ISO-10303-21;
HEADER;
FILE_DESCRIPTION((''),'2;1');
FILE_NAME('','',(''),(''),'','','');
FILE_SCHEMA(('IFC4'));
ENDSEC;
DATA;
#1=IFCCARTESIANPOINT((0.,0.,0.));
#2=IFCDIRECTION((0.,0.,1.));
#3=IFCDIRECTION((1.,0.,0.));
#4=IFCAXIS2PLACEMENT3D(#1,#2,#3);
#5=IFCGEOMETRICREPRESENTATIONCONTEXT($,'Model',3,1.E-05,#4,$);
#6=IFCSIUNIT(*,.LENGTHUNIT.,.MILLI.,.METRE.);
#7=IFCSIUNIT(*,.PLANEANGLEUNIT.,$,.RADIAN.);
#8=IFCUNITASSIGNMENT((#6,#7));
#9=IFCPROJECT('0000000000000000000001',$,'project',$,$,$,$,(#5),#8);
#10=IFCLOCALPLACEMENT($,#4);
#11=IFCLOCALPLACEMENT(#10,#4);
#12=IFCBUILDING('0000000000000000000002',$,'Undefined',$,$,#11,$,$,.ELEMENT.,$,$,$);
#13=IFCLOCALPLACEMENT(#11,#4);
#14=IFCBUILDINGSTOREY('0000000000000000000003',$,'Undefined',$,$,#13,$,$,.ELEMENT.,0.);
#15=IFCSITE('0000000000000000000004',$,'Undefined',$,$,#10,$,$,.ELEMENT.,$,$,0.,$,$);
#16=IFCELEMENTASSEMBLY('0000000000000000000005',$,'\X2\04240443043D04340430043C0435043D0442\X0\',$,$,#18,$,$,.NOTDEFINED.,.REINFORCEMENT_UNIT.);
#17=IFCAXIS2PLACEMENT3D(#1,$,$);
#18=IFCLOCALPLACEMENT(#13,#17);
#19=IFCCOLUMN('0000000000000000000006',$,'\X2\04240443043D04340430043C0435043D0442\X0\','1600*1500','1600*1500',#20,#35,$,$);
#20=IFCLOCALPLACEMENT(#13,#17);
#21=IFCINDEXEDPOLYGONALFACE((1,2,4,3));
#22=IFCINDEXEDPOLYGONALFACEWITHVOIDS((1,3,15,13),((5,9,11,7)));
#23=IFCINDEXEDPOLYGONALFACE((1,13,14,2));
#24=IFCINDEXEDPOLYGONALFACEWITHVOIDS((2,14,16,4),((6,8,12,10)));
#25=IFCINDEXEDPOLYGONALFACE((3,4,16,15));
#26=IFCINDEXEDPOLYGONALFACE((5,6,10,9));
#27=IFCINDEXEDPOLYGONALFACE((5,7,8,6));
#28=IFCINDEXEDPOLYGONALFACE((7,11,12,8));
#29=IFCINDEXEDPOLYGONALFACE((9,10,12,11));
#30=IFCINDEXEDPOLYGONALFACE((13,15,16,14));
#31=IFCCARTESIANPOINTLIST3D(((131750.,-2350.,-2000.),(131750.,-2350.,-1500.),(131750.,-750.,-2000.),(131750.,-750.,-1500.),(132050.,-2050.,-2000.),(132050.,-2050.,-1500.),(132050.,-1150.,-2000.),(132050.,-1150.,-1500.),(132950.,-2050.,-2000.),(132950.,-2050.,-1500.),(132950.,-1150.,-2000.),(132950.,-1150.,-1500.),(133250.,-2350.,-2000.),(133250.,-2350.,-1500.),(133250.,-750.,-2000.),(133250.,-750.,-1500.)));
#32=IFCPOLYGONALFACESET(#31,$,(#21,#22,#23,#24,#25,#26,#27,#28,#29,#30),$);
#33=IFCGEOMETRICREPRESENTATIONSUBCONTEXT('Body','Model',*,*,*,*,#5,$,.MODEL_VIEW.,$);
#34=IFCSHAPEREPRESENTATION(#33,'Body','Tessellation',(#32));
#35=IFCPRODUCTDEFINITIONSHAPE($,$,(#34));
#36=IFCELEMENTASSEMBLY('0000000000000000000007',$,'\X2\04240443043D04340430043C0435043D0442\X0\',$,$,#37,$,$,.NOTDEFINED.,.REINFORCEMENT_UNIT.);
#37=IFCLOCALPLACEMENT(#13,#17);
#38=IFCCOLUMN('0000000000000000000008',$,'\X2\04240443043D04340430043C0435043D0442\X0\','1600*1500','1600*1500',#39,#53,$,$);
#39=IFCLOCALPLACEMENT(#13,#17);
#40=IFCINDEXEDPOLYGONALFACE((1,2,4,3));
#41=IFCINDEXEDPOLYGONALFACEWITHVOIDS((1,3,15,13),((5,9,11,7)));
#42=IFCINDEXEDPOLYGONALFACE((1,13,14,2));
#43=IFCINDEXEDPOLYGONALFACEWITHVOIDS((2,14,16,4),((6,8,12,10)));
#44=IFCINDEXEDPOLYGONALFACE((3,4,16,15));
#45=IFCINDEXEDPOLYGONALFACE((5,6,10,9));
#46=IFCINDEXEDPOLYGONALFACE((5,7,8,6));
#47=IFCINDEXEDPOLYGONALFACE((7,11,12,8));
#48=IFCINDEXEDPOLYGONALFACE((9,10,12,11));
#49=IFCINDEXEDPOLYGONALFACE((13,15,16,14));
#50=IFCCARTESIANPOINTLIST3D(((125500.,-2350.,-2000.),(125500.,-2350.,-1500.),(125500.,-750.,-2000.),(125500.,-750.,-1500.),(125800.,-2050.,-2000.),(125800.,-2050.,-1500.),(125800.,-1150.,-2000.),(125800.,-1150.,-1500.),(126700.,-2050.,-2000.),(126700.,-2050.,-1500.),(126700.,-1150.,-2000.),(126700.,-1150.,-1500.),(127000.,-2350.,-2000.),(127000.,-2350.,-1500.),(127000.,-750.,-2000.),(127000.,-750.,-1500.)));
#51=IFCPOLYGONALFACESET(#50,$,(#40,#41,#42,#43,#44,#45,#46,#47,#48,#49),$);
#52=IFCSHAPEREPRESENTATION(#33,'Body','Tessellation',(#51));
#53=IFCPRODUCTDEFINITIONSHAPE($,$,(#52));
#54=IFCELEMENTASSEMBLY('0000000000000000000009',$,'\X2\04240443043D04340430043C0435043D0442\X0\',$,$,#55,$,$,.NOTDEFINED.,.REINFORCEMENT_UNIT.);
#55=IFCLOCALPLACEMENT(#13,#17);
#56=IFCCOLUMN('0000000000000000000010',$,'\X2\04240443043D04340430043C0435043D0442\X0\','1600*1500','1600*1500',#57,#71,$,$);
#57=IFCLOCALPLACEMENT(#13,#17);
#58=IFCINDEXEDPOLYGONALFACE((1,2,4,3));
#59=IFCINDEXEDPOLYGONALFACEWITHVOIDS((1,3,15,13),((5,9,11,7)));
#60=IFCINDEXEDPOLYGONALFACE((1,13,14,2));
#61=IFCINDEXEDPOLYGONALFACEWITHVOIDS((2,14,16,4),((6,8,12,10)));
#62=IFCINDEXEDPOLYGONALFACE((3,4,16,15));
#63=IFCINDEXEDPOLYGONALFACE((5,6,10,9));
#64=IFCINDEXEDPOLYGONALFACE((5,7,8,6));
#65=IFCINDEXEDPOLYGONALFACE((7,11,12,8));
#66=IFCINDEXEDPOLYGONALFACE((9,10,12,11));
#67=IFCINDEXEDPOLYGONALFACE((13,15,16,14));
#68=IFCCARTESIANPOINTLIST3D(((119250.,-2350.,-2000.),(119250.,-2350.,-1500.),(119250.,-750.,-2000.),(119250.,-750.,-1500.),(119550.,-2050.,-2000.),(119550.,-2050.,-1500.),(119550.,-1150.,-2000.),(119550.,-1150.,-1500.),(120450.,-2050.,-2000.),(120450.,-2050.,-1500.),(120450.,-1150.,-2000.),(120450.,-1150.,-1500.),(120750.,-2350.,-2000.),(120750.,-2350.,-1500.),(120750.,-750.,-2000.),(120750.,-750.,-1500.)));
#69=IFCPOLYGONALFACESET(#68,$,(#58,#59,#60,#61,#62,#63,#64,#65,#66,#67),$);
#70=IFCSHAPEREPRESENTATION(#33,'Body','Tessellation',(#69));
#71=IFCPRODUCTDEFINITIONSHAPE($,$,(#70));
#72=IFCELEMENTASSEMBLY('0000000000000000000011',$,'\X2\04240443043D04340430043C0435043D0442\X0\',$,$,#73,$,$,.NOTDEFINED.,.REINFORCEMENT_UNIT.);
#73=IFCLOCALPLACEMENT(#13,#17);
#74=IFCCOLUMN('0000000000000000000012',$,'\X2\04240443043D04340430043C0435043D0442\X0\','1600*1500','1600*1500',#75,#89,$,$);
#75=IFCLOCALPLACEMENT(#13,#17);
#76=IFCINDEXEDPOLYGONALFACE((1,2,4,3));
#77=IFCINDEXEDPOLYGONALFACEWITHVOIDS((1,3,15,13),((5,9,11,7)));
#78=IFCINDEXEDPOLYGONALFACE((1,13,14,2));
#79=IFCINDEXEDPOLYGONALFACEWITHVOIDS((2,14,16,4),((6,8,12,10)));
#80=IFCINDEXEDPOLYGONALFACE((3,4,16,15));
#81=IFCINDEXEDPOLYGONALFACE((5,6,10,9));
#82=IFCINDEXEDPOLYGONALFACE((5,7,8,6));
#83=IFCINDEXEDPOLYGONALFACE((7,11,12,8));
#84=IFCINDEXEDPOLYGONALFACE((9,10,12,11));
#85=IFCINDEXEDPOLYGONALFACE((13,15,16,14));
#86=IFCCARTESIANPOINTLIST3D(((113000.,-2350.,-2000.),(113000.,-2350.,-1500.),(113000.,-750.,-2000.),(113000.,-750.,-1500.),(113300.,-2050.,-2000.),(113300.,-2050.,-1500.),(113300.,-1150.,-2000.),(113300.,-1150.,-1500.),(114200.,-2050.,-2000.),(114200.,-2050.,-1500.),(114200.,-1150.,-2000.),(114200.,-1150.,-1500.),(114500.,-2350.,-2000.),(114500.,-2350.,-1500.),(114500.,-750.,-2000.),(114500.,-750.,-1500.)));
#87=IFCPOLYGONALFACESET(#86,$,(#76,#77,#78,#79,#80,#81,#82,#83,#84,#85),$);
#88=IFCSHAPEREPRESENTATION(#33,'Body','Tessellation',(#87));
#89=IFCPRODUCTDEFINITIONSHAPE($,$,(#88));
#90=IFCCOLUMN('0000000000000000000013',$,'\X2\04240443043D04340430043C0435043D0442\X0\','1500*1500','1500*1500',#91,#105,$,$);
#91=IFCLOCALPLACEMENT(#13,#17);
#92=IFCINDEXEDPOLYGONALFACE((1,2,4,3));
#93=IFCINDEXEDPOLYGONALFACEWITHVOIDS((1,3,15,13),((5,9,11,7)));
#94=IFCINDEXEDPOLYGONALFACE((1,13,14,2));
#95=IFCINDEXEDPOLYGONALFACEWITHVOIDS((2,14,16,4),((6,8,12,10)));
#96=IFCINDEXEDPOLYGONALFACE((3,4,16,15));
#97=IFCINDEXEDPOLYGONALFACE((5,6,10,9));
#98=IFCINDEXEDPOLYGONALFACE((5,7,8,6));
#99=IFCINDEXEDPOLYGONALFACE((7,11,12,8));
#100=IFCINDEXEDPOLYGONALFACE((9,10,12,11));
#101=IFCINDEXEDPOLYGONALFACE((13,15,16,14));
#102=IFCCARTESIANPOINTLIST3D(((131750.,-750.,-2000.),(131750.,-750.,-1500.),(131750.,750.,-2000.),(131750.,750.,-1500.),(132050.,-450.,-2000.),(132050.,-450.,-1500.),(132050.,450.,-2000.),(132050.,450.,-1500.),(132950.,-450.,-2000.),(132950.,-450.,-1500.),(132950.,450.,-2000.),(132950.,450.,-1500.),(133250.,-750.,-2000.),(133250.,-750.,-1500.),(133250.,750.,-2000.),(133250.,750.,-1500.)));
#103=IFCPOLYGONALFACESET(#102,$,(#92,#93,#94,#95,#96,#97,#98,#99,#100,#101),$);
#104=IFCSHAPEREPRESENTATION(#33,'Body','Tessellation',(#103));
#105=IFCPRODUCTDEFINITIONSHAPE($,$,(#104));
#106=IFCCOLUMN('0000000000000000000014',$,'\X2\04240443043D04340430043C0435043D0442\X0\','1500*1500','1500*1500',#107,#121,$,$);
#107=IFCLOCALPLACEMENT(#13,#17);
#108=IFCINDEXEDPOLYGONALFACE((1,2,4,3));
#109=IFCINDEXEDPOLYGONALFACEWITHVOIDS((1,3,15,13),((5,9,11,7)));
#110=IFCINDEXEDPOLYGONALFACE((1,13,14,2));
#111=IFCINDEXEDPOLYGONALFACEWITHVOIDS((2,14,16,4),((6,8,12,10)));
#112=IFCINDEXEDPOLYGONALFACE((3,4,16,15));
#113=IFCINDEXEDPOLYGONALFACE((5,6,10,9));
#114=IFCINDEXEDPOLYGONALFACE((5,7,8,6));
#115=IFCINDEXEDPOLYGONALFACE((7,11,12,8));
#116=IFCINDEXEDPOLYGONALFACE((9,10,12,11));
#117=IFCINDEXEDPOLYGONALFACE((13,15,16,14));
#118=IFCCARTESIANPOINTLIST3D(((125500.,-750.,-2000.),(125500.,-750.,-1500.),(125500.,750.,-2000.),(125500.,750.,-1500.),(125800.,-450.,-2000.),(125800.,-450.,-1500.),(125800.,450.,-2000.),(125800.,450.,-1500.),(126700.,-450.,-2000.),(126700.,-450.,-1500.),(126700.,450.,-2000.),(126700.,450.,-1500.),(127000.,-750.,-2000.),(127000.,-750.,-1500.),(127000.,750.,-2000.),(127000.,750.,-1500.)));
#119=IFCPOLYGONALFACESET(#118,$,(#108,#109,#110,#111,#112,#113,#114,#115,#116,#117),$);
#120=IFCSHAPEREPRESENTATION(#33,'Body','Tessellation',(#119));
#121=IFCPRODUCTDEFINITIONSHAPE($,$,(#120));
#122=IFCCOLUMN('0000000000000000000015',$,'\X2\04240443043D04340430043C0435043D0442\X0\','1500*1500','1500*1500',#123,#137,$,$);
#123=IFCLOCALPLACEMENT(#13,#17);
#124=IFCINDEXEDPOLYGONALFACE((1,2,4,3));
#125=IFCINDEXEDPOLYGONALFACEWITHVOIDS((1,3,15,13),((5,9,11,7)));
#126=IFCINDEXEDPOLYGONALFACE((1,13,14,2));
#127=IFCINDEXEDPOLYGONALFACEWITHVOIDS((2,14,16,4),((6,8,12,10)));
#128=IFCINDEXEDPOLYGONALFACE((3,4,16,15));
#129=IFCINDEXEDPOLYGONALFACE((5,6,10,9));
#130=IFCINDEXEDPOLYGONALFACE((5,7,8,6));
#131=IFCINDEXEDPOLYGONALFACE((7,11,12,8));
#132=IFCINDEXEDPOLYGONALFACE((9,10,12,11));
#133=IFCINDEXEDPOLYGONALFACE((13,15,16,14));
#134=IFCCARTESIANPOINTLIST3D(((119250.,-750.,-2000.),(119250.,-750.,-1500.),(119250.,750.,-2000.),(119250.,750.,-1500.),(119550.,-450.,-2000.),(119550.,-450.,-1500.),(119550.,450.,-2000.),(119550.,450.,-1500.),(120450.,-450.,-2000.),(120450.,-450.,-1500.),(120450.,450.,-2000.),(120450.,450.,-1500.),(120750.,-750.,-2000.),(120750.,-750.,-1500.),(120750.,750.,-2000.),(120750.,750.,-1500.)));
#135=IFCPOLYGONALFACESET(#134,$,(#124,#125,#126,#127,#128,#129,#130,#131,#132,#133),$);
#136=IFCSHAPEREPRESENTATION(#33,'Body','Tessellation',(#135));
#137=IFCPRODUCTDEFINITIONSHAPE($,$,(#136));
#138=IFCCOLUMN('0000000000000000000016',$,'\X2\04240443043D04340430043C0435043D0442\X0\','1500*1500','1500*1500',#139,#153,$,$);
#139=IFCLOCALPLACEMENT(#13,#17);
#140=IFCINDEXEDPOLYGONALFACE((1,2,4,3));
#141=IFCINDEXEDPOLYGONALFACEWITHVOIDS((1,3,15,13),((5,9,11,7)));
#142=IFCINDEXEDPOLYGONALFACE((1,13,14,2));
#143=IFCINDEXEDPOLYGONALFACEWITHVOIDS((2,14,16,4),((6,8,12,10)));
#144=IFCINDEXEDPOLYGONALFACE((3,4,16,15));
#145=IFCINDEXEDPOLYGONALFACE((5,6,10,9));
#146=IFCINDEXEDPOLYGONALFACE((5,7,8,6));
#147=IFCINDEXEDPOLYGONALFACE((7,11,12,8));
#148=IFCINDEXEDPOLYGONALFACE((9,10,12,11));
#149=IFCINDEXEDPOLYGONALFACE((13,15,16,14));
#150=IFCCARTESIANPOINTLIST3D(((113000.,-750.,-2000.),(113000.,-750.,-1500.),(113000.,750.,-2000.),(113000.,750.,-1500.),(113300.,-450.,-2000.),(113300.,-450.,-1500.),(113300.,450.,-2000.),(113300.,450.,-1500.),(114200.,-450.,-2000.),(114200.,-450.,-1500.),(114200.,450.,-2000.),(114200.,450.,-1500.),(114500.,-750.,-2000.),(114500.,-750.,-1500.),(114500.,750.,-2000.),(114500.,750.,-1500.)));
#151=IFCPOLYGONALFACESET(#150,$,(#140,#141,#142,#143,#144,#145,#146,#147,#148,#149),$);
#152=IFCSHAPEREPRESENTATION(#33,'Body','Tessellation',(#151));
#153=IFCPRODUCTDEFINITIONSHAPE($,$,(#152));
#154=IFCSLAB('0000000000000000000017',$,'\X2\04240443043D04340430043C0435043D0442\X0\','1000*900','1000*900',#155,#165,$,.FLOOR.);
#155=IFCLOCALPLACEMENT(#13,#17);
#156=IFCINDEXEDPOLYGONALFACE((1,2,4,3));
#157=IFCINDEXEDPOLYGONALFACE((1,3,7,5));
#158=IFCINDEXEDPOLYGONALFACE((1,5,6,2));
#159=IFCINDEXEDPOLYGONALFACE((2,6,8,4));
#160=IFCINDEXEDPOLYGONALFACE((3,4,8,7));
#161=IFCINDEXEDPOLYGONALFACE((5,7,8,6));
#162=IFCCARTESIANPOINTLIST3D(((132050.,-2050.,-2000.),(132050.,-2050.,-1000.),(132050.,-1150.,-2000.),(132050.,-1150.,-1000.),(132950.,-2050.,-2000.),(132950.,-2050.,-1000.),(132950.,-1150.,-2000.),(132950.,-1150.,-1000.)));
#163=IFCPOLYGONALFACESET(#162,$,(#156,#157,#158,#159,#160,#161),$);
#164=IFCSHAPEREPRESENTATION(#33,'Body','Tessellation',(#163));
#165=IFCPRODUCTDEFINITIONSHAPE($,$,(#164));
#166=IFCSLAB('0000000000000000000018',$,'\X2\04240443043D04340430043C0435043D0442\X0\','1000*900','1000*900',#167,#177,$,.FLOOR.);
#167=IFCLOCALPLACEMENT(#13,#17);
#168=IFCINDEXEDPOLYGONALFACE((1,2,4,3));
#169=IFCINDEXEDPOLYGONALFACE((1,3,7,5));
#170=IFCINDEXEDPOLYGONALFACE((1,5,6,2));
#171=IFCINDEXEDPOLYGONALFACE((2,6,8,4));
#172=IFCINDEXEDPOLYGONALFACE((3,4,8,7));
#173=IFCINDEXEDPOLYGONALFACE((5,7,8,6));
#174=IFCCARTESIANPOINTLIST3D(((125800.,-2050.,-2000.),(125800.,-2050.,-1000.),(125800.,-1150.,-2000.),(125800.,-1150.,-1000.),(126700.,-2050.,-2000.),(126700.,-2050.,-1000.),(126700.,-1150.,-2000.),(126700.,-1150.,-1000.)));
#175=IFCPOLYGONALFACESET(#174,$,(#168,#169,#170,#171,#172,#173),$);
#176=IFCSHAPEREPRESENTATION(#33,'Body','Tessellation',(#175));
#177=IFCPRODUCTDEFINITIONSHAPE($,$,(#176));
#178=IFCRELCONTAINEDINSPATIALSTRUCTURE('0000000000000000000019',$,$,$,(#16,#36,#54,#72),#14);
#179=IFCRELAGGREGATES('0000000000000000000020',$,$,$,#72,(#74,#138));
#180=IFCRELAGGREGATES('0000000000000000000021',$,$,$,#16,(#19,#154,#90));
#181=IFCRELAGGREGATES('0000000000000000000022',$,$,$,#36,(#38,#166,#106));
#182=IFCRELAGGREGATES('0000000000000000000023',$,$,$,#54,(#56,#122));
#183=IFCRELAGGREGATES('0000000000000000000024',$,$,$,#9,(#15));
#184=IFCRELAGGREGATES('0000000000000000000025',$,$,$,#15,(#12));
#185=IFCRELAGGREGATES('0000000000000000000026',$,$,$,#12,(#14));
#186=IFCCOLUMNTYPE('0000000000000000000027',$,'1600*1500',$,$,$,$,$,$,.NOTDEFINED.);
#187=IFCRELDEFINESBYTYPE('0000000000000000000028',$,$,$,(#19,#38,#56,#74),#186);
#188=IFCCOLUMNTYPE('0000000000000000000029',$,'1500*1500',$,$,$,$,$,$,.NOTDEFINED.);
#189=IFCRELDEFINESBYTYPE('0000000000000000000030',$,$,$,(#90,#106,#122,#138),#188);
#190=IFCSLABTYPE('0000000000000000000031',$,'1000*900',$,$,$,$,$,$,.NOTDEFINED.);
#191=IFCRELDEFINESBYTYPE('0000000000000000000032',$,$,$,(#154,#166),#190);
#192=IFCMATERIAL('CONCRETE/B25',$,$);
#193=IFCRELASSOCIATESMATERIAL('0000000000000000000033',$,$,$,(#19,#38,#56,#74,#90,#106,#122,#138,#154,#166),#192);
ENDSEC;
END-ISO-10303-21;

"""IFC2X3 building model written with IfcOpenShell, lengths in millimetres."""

from ifc_helpers import new_model, si_unit, frame, origin_with_axes, origin_2d_with_axis, place, context, subcontext, project, spatial, polyline, rectangle, outline, extrude, boolean, material, type_object, element, aggregate, save


model = new_model("IFC2X3")

# Units and contexts
model_context = context("Model", 3, precision=1e-05, world=origin_with_axes())
body_context = subcontext(model_context, "Body", "Model", "MODEL_VIEW")
ifc_project = project(units=[si_unit("LENGTHUNIT", "METRE", prefix="MILLI"), si_unit("PLANEANGLEUNIT", "RADIAN")], contexts=[model_context])

# Site, building, storey
site_placement = place(None, origin_with_axes())
site = spatial("IfcSite", under=ifc_project, at=site_placement, Name="Undefined", CompositionType="ELEMENT", RefElevation=0.0)
building_placement = place(site_placement, origin_with_axes())
building = spatial("IfcBuilding", under=site, at=building_placement, Name="Undefined", CompositionType="ELEMENT")
storey_placement = place(building_placement, origin_with_axes())
storey = spatial("IfcBuildingStorey", under=building, at=storey_placement, Name="Undefined", CompositionType="ELEMENT", Elevation=0.0)

# Element assemblies, columns
assembly_1_placement = place(storey_placement, origin_with_axes())
assembly_1 = element("IfcElementAssembly", 1, at=assembly_1_placement, inside=storey, Name="Фундамент", AssemblyPlace="NOTDEFINED", PredefinedType="REINFORCEMENT_UNIT")
ifc_material_1 = material(Name="CONCRETE/B25")
column_type_1 = type_object("IfcColumnType", Name="1600*1500", PredefinedType="NOTDEFINED")
column_1_placement = place(assembly_1_placement, frame((132500.0, -1550.0, -2000.0), z_axis=(0.0, 0.0, 1.0), x_axis=(0.0, -1.0, 0.0)))
column_1 = element("IfcColumn", 2, at=column_1_placement, type_object=column_type_1, material=ifc_material_1, Name="Фундамент", Description="1600*1500", ObjectType="1600*1500", context=body_context, shape_type="CSG", body=[
    boolean("DIFFERENCE", extrude(rectangle(XDim=1500.0, YDim=1600.0, at=origin_2d_with_axis()), frame((0.0, 0.0, 500.0), z_axis=(0.0, 0.0, -1.0), x_axis=(0.0, 1.0, 0.0)), (0.0, 0.0, 1.0), 500.0), extrude(outline(polyline([(0.0, 0.0), (900.0, 0.0), (900.0, 900.0), (0.0, 900.0), (0.0, 0.0)])), frame((-400.0, -450.0, -100.0), z_axis=(0.0, 0.0, 1.0), x_axis=(1.0, 0.0, 0.0)), (0.0, 0.0, 1.0), 700.0)),
])
assembly_2_placement = place(storey_placement, origin_with_axes())
assembly_2 = element("IfcElementAssembly", 3, at=assembly_2_placement, inside=storey, Name="Фундамент", AssemblyPlace="NOTDEFINED", PredefinedType="REINFORCEMENT_UNIT")
column_2_placement = place(assembly_2_placement, frame((126250.0, -1550.0, -2000.0), z_axis=(0.0, 0.0, 1.0), x_axis=(0.0, -1.0, 0.0)))
column_2 = element("IfcColumn", 4, at=column_2_placement, type_object=column_type_1, material=ifc_material_1, Name="Фундамент", Description="1600*1500", ObjectType="1600*1500", context=body_context, shape_type="CSG", body=[
    boolean("DIFFERENCE", extrude(rectangle(XDim=1500.0, YDim=1600.0, at=origin_2d_with_axis()), frame((0.0, 0.0, 500.0), z_axis=(0.0, 0.0, -1.0), x_axis=(0.0, 1.0, 0.0)), (0.0, 0.0, 1.0), 500.0), extrude(outline(polyline([(0.0, 0.0), (900.0, 0.0), (900.0, 900.0), (0.0, 900.0), (0.0, 0.0)])), frame((-400.0, -450.0, -100.0), z_axis=(0.0, 0.0, 1.0), x_axis=(1.0, 0.0, 0.0)), (0.0, 0.0, 1.0), 700.0)),
])
assembly_3_placement = place(storey_placement, origin_with_axes())
assembly_3 = element("IfcElementAssembly", 5, at=assembly_3_placement, inside=storey, Name="Фундамент", AssemblyPlace="NOTDEFINED", PredefinedType="REINFORCEMENT_UNIT")
column_3_placement = place(assembly_3_placement, frame((120000.0, -1550.0, -2000.0), z_axis=(0.0, 0.0, 1.0), x_axis=(0.0, -1.0, 0.0)))
column_3 = element("IfcColumn", 6, at=column_3_placement, type_object=column_type_1, material=ifc_material_1, Name="Фундамент", Description="1600*1500", ObjectType="1600*1500", context=body_context, shape_type="CSG", body=[
    boolean("DIFFERENCE", extrude(rectangle(XDim=1500.0, YDim=1600.0, at=origin_2d_with_axis()), frame((0.0, 0.0, 500.0), z_axis=(0.0, 0.0, -1.0), x_axis=(0.0, 1.0, 0.0)), (0.0, 0.0, 1.0), 500.0), extrude(outline(polyline([(0.0, 0.0), (900.0, 0.0), (900.0, 900.0), (0.0, 900.0), (0.0, 0.0)])), frame((-400.0, -450.0, -100.0), z_axis=(0.0, 0.0, 1.0), x_axis=(1.0, 0.0, 0.0)), (0.0, 0.0, 1.0), 700.0)),
])
assembly_4_placement = place(storey_placement, origin_with_axes())
assembly_4 = element("IfcElementAssembly", 7, at=assembly_4_placement, inside=storey, Name="Фундамент", AssemblyPlace="NOTDEFINED", PredefinedType="REINFORCEMENT_UNIT")
column_4_placement = place(assembly_4_placement, frame((113750.0, -1550.0, -2000.0), z_axis=(0.0, 0.0, 1.0), x_axis=(0.0, -1.0, 0.0)))
column_4 = element("IfcColumn", 8, at=column_4_placement, type_object=column_type_1, material=ifc_material_1, Name="Фундамент", Description="1600*1500", ObjectType="1600*1500", context=body_context, shape_type="CSG", body=[
    boolean("DIFFERENCE", extrude(rectangle(XDim=1500.0, YDim=1600.0, at=origin_2d_with_axis()), frame((0.0, 0.0, 500.0), z_axis=(0.0, 0.0, -1.0), x_axis=(0.0, 1.0, 0.0)), (0.0, 0.0, 1.0), 500.0), extrude(outline(polyline([(0.0, 0.0), (900.0, 0.0), (900.0, 900.0), (0.0, 900.0), (0.0, 0.0)])), frame((-400.0, -450.0, -100.0), z_axis=(0.0, 0.0, 1.0), x_axis=(1.0, 0.0, 0.0)), (0.0, 0.0, 1.0), 700.0)),
])

# Columns
column_type_2 = type_object("IfcColumnType", Name="1500*1500", PredefinedType="NOTDEFINED")
column_5_placement = place(assembly_1_placement, frame((132500.0, 0.0, -2000.0), z_axis=(0.0, 0.0, 1.0), x_axis=(0.0, -1.0, 0.0)))
column_5 = element("IfcColumn", 9, at=column_5_placement, type_object=column_type_2, material=ifc_material_1, Name="Фундамент", Description="1500*1500", ObjectType="1500*1500", context=body_context, shape_type="CSG", body=[
    boolean("DIFFERENCE", extrude(rectangle(XDim=1500.0, YDim=1500.0, at=origin_2d_with_axis()), frame((0.0, 0.0, 500.0), z_axis=(0.0, 0.0, -1.0), x_axis=(0.0, 1.0, 0.0)), (0.0, 0.0, 1.0), 500.0), extrude(outline(polyline([(0.0, 0.0), (900.0, 0.0), (900.0, 900.0), (0.0, 900.0), (0.0, 0.0)])), frame((-450.0, -450.0, -100.0), z_axis=(0.0, 0.0, 1.0), x_axis=(1.0, 0.0, 0.0)), (0.0, 0.0, 1.0), 700.0)),
])
column_6_placement = place(assembly_2_placement, frame((126250.0, 0.0, -2000.0), z_axis=(0.0, 0.0, 1.0), x_axis=(0.0, -1.0, 0.0)))
column_6 = element("IfcColumn", 10, at=column_6_placement, type_object=column_type_2, material=ifc_material_1, Name="Фундамент", Description="1500*1500", ObjectType="1500*1500", context=body_context, shape_type="CSG", body=[
    boolean("DIFFERENCE", extrude(rectangle(XDim=1500.0, YDim=1500.0, at=origin_2d_with_axis()), frame((0.0, 0.0, 500.0), z_axis=(0.0, 0.0, -1.0), x_axis=(0.0, 1.0, 0.0)), (0.0, 0.0, 1.0), 500.0), extrude(outline(polyline([(0.0, 0.0), (900.0, 0.0), (900.0, 900.0), (0.0, 900.0), (0.0, 0.0)])), frame((-450.0, -450.0, -100.0), z_axis=(0.0, 0.0, 1.0), x_axis=(1.0, 0.0, 0.0)), (0.0, 0.0, 1.0), 700.0)),
])
column_7_placement = place(assembly_3_placement, frame((120000.0, 0.0, -2000.0), z_axis=(0.0, 0.0, 1.0), x_axis=(0.0, -1.0, 0.0)))
column_7 = element("IfcColumn", 11, at=column_7_placement, type_object=column_type_2, material=ifc_material_1, Name="Фундамент", Description="1500*1500", ObjectType="1500*1500", context=body_context, shape_type="CSG", body=[
    boolean("DIFFERENCE", extrude(rectangle(XDim=1500.0, YDim=1500.0, at=origin_2d_with_axis()), frame((0.0, 0.0, 500.0), z_axis=(0.0, 0.0, -1.0), x_axis=(0.0, 1.0, 0.0)), (0.0, 0.0, 1.0), 500.0), extrude(outline(polyline([(0.0, 0.0), (900.0, 0.0), (900.0, 900.0), (0.0, 900.0), (0.0, 0.0)])), frame((-450.0, -450.0, -100.0), z_axis=(0.0, 0.0, 1.0), x_axis=(1.0, 0.0, 0.0)), (0.0, 0.0, 1.0), 700.0)),
])
column_8_placement = place(assembly_4_placement, frame((113750.0, 0.0, -2000.0), z_axis=(0.0, 0.0, 1.0), x_axis=(0.0, -1.0, 0.0)))
column_8 = element("IfcColumn", 12, at=column_8_placement, type_object=column_type_2, material=ifc_material_1, Name="Фундамент", Description="1500*1500", ObjectType="1500*1500", context=body_context, shape_type="CSG", body=[
    boolean("DIFFERENCE", extrude(rectangle(XDim=1500.0, YDim=1500.0, at=origin_2d_with_axis()), frame((0.0, 0.0, 500.0), z_axis=(0.0, 0.0, -1.0), x_axis=(0.0, 1.0, 0.0)), (0.0, 0.0, 1.0), 500.0), extrude(outline(polyline([(0.0, 0.0), (900.0, 0.0), (900.0, 900.0), (0.0, 900.0), (0.0, 0.0)])), frame((-450.0, -450.0, -100.0), z_axis=(0.0, 0.0, 1.0), x_axis=(1.0, 0.0, 0.0)), (0.0, 0.0, 1.0), 700.0)),
])

# Slabs
slab_type_1 = type_object("IfcSlabType", Name="1000*900", PredefinedType="NOTDEFINED")
slab_1_placement = place(assembly_1_placement, frame((132050.0, -1150.0, -1500.0), z_axis=(0.0, 0.0, 1.0), x_axis=(0.0, -1.0, 0.0)))
slab_1 = element("IfcSlab", 13, at=slab_1_placement, type_object=slab_type_1, material=ifc_material_1, Name="Фундамент", Description="1000*900", ObjectType="1000*900", PredefinedType="FLOOR", context=body_context, shape_type="SweptSolid", body=[
    extrude(outline(polyline([(0.0, 0.0), (900.0, 0.0), (900.0, 900.0), (0.0, 900.0), (0.0, 0.0)])), frame((0.0, 0.0, -500.0), z_axis=(0.0, 0.0, 1.0), x_axis=(1.0, 0.0, 0.0)), (0.0, 0.0, 1.0), 1000.0),
])
slab_2_placement = place(assembly_2_placement, frame((125800.0, -1150.0, -1500.0), z_axis=(0.0, 0.0, 1.0), x_axis=(0.0, -1.0, 0.0)))
slab_2 = element("IfcSlab", 14, at=slab_2_placement, type_object=slab_type_1, material=ifc_material_1, Name="Фундамент", Description="1000*900", ObjectType="1000*900", PredefinedType="FLOOR", context=body_context, shape_type="SweptSolid", body=[
    extrude(outline(polyline([(0.0, 0.0), (900.0, 0.0), (900.0, 900.0), (0.0, 900.0), (0.0, 0.0)])), frame((0.0, 0.0, -500.0), z_axis=(0.0, 0.0, 1.0), x_axis=(1.0, 0.0, 0.0)), (0.0, 0.0, 1.0), 1000.0),
])
aggregate(assembly_4, [column_4, column_8])
aggregate(assembly_1, [column_1, slab_1, column_5])
aggregate(assembly_2, [column_2, slab_2, column_6])
aggregate(assembly_3, [column_3, column_7])

save(model, "model.ifc")
